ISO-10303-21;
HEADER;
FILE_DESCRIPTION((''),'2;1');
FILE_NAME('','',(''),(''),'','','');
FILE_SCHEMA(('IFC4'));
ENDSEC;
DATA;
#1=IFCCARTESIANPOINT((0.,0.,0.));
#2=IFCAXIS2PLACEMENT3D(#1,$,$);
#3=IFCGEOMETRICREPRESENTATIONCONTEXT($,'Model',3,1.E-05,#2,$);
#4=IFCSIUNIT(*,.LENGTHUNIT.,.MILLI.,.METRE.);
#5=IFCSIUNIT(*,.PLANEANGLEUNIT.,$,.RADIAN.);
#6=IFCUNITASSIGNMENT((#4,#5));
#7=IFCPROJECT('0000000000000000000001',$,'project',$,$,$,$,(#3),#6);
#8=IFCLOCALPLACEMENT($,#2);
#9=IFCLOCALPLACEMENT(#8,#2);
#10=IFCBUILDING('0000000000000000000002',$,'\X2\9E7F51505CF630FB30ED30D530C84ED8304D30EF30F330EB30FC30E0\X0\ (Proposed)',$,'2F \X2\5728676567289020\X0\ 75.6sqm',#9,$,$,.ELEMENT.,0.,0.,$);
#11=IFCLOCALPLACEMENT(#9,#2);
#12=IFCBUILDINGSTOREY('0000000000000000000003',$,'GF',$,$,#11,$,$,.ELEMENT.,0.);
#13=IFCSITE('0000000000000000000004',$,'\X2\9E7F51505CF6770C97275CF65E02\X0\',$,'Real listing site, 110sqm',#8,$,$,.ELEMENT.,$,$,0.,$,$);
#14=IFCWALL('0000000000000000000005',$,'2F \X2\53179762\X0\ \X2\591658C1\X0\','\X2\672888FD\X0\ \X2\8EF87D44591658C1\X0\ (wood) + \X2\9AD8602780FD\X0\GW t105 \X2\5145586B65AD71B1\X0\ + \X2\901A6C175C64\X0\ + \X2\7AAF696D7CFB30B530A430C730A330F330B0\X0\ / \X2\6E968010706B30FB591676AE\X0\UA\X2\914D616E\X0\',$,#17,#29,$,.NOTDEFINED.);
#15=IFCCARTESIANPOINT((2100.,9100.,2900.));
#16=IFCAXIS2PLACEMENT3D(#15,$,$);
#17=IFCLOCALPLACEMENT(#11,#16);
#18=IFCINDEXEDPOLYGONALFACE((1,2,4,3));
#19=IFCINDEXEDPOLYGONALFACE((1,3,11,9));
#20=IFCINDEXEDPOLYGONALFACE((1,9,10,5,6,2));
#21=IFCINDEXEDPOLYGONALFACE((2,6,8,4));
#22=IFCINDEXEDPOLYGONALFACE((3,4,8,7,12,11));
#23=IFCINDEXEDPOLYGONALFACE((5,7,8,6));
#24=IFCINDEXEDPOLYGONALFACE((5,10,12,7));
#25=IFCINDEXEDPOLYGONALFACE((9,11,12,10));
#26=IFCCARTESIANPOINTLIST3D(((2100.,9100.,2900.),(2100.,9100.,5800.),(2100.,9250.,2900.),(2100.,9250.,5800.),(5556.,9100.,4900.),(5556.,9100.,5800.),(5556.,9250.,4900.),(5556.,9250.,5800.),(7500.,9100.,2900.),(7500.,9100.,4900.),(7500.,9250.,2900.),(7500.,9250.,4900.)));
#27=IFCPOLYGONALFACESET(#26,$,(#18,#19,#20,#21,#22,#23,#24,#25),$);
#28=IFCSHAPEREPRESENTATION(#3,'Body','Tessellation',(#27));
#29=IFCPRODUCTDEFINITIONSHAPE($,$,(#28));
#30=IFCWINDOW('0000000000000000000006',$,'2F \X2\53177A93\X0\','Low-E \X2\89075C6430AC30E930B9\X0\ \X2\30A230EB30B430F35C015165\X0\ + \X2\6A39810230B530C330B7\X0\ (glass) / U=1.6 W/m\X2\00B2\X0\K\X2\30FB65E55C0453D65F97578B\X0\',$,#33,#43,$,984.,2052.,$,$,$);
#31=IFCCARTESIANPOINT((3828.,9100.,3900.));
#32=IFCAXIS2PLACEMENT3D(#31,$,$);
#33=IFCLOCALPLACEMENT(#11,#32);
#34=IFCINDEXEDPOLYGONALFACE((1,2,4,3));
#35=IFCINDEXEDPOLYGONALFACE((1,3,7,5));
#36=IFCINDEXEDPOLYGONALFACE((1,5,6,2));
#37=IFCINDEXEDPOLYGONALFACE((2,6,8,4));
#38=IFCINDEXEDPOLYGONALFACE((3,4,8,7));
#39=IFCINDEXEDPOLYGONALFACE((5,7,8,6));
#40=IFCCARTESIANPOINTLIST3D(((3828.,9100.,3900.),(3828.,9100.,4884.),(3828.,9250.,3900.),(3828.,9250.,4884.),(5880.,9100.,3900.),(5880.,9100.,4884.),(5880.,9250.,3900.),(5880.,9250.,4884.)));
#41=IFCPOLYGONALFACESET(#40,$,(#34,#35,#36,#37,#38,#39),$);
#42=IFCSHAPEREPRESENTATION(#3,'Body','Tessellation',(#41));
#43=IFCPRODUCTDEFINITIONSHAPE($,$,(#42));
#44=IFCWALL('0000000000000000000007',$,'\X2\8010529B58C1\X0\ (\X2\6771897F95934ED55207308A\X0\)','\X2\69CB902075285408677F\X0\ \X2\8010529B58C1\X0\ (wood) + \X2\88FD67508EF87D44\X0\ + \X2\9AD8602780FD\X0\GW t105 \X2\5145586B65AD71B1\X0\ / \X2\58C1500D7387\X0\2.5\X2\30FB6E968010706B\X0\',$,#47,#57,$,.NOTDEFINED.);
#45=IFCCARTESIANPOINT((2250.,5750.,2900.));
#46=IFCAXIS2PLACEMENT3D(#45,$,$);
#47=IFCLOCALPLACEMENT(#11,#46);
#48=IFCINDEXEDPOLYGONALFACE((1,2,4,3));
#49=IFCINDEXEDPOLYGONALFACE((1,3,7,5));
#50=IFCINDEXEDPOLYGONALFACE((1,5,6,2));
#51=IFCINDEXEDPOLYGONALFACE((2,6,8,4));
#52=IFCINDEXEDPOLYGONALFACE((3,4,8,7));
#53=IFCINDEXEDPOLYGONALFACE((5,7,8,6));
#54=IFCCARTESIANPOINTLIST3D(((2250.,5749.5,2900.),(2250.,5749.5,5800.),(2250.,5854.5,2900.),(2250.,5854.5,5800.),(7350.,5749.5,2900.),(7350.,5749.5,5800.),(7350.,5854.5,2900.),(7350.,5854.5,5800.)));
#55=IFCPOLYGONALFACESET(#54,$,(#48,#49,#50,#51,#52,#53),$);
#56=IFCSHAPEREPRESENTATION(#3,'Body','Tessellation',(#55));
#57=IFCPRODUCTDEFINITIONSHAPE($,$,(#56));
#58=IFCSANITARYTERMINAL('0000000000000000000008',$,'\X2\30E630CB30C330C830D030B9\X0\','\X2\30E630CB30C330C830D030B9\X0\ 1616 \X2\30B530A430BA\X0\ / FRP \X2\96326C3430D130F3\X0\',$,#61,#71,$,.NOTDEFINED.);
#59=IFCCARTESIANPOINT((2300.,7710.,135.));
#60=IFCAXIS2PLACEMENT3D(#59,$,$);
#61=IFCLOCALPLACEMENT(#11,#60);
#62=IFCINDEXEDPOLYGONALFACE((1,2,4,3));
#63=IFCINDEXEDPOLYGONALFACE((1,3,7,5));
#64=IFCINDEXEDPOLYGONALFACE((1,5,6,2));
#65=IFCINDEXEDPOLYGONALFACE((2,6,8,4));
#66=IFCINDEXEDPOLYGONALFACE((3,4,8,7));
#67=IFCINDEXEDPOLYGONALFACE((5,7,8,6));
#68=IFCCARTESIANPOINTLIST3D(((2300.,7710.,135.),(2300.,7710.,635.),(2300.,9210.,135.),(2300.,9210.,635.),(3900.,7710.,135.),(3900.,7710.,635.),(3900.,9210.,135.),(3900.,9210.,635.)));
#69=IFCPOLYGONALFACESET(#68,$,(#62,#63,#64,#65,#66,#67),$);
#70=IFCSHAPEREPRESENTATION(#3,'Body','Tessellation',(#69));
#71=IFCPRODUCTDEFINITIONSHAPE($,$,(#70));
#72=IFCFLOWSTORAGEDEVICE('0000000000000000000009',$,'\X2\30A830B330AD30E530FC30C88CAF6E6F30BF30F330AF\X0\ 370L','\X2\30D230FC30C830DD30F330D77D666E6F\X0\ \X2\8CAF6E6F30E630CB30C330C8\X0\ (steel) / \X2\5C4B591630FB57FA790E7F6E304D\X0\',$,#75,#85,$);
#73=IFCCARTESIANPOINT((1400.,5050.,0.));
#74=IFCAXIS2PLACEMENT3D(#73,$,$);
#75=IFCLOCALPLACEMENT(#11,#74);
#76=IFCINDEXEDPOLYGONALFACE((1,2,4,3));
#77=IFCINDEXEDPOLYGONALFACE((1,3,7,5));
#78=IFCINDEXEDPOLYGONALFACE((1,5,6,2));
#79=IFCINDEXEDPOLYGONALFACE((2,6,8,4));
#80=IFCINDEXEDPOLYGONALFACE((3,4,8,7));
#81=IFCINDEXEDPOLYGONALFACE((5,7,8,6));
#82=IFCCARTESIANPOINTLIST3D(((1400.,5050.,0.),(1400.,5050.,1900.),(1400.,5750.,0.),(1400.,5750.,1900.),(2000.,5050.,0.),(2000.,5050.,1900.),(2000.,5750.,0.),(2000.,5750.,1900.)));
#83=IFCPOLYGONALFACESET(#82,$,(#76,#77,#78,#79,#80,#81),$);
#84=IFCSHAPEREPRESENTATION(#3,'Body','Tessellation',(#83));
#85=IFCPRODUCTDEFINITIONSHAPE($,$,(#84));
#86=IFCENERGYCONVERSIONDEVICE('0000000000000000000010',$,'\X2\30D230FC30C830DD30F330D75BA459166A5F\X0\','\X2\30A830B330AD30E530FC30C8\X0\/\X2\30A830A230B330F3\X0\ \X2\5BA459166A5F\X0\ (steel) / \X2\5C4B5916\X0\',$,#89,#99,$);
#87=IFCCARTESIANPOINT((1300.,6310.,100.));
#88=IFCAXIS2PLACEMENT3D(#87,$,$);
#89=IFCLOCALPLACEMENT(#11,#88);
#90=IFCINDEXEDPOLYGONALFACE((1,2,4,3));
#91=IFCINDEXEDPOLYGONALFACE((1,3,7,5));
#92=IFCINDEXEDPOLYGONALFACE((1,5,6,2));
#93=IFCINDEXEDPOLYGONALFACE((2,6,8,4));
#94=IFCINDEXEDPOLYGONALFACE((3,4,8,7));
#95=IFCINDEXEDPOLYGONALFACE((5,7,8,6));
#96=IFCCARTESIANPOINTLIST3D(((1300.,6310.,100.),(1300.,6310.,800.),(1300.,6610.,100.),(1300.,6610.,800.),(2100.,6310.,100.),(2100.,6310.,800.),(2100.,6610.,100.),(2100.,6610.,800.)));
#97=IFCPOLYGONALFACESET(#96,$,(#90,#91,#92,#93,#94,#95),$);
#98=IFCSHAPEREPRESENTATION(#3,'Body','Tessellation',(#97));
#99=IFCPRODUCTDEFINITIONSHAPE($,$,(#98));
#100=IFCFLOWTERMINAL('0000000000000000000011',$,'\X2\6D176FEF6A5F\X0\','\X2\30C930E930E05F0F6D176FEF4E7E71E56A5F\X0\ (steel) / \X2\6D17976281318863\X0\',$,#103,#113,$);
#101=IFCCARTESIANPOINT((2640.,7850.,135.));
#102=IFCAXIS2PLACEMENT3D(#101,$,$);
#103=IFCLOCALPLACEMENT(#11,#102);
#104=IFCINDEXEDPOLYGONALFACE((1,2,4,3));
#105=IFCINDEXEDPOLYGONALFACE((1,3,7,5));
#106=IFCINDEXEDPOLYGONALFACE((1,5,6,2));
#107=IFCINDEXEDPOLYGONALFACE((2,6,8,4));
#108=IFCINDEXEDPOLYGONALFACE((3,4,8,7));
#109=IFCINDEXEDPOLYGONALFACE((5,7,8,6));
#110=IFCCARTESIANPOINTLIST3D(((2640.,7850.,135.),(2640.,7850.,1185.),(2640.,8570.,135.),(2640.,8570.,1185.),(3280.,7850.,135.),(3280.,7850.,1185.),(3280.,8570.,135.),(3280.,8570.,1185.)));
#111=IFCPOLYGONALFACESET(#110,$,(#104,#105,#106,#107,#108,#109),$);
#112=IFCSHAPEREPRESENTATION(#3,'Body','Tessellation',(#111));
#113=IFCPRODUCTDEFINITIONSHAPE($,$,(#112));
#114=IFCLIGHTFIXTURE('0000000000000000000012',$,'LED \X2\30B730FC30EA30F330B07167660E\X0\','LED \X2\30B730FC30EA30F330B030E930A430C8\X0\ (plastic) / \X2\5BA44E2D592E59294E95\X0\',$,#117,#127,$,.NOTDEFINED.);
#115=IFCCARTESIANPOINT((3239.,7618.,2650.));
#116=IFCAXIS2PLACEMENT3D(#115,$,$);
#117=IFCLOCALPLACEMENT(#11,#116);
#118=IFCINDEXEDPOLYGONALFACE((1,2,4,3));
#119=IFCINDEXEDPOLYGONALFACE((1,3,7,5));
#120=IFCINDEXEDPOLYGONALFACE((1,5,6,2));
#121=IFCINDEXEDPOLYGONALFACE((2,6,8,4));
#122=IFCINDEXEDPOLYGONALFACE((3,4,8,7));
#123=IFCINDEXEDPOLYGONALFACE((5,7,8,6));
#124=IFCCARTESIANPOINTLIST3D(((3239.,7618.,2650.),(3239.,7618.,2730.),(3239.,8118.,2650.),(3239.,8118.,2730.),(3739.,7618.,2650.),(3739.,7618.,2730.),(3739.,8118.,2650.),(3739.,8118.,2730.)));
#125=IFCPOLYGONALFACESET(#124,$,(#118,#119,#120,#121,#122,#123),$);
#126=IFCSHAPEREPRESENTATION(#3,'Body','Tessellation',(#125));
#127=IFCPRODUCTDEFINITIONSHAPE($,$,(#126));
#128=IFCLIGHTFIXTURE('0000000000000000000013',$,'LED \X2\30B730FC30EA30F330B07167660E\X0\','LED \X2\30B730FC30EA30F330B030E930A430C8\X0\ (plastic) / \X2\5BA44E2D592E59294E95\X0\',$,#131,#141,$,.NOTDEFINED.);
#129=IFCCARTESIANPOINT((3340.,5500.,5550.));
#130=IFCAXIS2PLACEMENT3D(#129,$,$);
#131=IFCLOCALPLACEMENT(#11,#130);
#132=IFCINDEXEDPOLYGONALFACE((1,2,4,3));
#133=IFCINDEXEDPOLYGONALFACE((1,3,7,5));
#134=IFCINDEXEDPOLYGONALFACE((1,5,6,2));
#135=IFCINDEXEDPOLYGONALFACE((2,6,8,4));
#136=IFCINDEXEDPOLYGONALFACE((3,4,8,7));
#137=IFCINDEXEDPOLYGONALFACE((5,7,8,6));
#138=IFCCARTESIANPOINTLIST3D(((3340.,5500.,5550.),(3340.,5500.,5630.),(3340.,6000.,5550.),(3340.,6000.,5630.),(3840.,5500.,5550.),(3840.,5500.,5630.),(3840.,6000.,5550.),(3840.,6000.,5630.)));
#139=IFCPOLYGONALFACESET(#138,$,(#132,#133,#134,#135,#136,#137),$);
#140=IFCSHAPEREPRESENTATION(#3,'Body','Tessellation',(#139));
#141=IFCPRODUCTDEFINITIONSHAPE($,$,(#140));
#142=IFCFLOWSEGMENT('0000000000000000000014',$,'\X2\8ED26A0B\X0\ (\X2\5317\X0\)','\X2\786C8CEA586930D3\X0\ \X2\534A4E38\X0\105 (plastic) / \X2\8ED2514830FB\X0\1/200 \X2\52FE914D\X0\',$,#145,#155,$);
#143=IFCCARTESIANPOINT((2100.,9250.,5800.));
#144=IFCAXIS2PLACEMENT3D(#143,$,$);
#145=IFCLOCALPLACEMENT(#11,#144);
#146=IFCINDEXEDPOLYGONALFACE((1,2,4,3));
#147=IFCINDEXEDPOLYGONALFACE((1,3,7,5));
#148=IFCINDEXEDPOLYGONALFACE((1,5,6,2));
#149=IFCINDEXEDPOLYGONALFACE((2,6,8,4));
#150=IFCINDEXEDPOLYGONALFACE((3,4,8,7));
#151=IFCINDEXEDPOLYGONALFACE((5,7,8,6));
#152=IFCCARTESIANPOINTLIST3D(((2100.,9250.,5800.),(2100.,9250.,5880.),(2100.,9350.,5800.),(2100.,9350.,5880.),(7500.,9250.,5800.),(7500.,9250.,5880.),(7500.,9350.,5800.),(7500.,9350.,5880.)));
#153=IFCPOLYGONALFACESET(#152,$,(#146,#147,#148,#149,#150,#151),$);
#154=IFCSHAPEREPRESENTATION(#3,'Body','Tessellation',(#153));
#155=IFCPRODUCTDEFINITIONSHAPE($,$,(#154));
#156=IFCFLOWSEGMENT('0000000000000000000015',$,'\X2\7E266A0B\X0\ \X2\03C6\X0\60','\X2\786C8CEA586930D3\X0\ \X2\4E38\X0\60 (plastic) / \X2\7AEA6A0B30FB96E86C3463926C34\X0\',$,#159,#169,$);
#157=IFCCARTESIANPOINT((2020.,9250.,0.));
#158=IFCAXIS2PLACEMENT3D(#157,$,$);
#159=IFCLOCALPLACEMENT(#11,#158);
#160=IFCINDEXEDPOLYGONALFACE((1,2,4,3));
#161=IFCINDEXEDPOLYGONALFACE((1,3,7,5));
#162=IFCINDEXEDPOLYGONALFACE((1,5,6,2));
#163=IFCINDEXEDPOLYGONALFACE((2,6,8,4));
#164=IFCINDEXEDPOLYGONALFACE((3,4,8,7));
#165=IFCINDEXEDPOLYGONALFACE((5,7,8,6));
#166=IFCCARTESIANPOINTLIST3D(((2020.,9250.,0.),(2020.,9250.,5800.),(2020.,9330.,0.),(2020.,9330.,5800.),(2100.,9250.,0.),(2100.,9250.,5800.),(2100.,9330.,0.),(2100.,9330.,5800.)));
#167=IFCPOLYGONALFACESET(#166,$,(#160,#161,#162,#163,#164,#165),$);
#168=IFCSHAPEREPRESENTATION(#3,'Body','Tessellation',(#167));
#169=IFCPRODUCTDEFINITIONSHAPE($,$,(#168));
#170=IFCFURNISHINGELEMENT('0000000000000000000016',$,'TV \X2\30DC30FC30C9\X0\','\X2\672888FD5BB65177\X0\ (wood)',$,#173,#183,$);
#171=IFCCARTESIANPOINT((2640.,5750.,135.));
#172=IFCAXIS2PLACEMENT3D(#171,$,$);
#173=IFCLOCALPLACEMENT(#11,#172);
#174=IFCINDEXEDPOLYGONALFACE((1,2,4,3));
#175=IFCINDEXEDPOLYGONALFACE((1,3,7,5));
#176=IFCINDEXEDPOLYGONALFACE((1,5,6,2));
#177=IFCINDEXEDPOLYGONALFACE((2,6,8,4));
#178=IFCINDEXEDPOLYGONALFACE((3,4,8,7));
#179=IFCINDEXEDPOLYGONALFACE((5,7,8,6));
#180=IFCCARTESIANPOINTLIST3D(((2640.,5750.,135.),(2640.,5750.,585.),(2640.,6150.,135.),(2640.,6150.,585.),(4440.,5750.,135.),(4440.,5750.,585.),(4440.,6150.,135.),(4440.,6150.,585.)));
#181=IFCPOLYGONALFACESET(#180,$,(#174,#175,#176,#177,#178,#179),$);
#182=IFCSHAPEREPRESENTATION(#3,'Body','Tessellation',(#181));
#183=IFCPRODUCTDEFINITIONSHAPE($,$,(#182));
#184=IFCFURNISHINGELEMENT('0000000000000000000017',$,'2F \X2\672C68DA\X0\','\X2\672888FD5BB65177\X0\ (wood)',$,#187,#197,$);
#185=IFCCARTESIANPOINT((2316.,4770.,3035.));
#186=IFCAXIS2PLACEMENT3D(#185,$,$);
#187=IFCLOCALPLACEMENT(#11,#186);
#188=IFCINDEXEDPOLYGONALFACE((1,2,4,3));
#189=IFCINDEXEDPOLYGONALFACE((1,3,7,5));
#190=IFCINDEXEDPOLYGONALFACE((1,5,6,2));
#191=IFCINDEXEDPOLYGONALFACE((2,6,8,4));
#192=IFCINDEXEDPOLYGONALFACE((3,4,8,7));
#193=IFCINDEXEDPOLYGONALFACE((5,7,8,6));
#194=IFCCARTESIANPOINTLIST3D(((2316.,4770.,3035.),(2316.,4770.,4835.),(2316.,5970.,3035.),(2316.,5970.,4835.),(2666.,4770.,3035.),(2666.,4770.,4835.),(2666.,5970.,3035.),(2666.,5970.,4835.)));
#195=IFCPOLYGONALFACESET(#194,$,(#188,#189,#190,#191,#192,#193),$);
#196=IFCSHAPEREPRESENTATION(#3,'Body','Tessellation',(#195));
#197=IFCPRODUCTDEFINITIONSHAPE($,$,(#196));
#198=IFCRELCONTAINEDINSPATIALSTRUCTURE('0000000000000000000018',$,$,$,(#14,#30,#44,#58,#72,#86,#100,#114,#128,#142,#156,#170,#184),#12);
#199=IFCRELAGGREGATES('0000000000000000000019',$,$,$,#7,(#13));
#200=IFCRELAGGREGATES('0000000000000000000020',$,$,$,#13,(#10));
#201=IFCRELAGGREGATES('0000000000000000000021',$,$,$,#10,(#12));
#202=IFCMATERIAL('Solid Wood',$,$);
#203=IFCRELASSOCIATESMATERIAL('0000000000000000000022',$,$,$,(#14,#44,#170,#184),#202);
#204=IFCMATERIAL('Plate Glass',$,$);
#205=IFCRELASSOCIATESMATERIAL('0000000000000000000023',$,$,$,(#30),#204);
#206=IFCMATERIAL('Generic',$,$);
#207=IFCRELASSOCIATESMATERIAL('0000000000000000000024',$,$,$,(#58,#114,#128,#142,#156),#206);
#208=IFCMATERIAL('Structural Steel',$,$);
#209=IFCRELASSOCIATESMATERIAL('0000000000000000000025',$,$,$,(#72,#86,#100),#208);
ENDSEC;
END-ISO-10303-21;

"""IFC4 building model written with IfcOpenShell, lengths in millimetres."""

from ifc_helpers import new_model, si_unit, frame, frame_2d, origin, place, context, project, spatial, rectangle, extrude, material, element, fill, save


model = new_model("IFC4")

# Units and contexts
model_context = context("Model", 3, precision=1e-05, world=origin())
ifc_project = project(units=[si_unit("LENGTHUNIT", "METRE", prefix="MILLI"), si_unit("PLANEANGLEUNIT", "RADIAN")], contexts=[model_context])

# Site, building, storey
site_placement = place(None, origin())
site = spatial("IfcSite", under=ifc_project, at=site_placement, Name="鹿児島県霧島市", ObjectType="Real listing site, 110sqm", CompositionType="ELEMENT", RefElevation=0.0)
building_placement = place(site_placement, origin())
building = spatial("IfcBuilding", under=site, at=building_placement, Name="鹿児島・ロフト付きワンルーム (Proposed)", ObjectType="2F 在来木造 75.6sqm", CompositionType="ELEMENT", ElevationOfRefHeight=0.0, ElevationOfTerrain=0.0)
storey_placement = place(building_placement, origin())
storey = spatial("IfcBuildingStorey", under=building, at=storey_placement, Name="GF", CompositionType="ELEMENT", Elevation=0.0)

# Shared definitions
ifc_material_1 = material(Name="Solid Wood")

# Shared definitions
ifc_material_2 = material(Name="Plate Glass")

# Wall, opening, window
wall_1_placement = place(storey_placement, frame((2100.0, 9100.0, 2900.0)))
wall_1 = element("IfcWall", 1, at=wall_1_placement, inside=storey, material=ifc_material_1, Name="2F 北面 外壁", Description="木製 軸組外壁 (wood) + 高性能GW t105 充填断熱 + 通気層 + 窯業系サイディング / 準耐火・外皮UA配慮", PredefinedType="NOTDEFINED", context=model_context, shape_type="SweptSolid", body=[
    extrude(rectangle(XDim=5400.0, YDim=150.0, at=frame_2d((2700.0, 75.0))), frame((2100.0, 9100.0, 2900.0)), (0.0, 0.0, 1.0), 2900.0),
])
opening_1_placement = place(storey_placement, frame((3828.0, 9100.0, 3900.0)))
opening_1 = element("IfcOpeningElement", 2, at=opening_1_placement, cuts=wall_1, PredefinedType="NOTDEFINED", context=model_context, shape_type="SweptSolid", body=[
    extrude(rectangle(XDim=2052.0, YDim=150.0, at=frame_2d((1026.0, 75.0))), frame((3828.0, 9100.0, 3900.0)), (0.0, 0.0, 1.0), 984.0),
])
window_1_placement = place(storey_placement, frame((3828.0, 9100.0, 3900.0)))
window_1 = element("IfcWindow", 3, at=window_1_placement, inside=storey, material=ifc_material_2, Name="2F 北窓", Description="Low-E 複層ガラス アルゴン封入 + 樹脂サッシ (glass) / U=1.6 W/m²K・日射取得型", OverallHeight=984.0, OverallWidth=2052.0, context=model_context, shape_type="SweptSolid", body=[
    extrude(rectangle(XDim=2052.0, YDim=150.0, at=frame_2d((1026.0, 75.0))), frame((3828.0, 9100.0, 3900.0)), (0.0, 0.0, 1.0), 984.0),
])
fill(opening_1, window_1)

# Wall
wall_2_placement = place(storey_placement, frame((2250.0, 5750.0, 2900.0)))
element("IfcWall", 4, at=wall_2_placement, inside=storey, material=ifc_material_1, Name="耐力壁 (東西間仕切り)", Description="構造用合板 耐力壁 (wood) + 製材軸組 + 高性能GW t105 充填断熱 / 壁倍率2.5・準耐火", PredefinedType="NOTDEFINED", context=model_context, shape_type="SweptSolid", body=[
    extrude(rectangle(XDim=5100.0, YDim=105.0, at=frame_2d((2550.0, 52.0))), frame((2250.0, 5750.0, 2900.0)), (0.0, 0.0, 1.0), 2900.0),
])

# Sanitary terminal
ifc_material_3 = material(Name="Generic")
sanitary_terminal_placement = place(storey_placement, frame((2300.0, 7710.0, 135.0)))
element("IfcSanitaryTerminal", 5, at=sanitary_terminal_placement, inside=storey, material=ifc_material_3, Name="ユニットバス", Description="ユニットバス 1616 サイズ / FRP 防水パン", PredefinedType="NOTDEFINED", context=model_context, shape_type="SweptSolid", body=[
    extrude(rectangle(XDim=1600.0, YDim=1500.0, at=frame_2d((800.0, 750.0))), frame((2300.0, 7710.0, 135.0)), (0.0, 0.0, 1.0), 500.0),
])

# Flow storage device
ifc_material_4 = material(Name="Structural Steel")
flow_storage_device_placement = place(storey_placement, frame((1400.0, 5050.0, 0.0)))
element("IfcFlowStorageDevice", 6, at=flow_storage_device_placement, inside=storey, material=ifc_material_4, Name="エコキュート貯湯タンク 370L", Description="ヒートポンプ給湯 貯湯ユニット (steel) / 屋外・基礎置き", context=model_context, shape_type="SweptSolid", body=[
    extrude(rectangle(XDim=600.0, YDim=700.0, at=frame_2d((300.0, 350.0))), frame((1400.0, 5050.0, 0.0)), (0.0, 0.0, 1.0), 1900.0),
])

# Energy conversion device
energy_conversion_device_placement = place(storey_placement, frame((1300.0, 6310.0, 100.0)))
element("IfcEnergyConversionDevice", 7, at=energy_conversion_device_placement, inside=storey, material=ifc_material_4, Name="ヒートポンプ室外機", Description="エコキュート/エアコン 室外機 (steel) / 屋外", context=model_context, shape_type="SweptSolid", body=[
    extrude(rectangle(XDim=800.0, YDim=300.0, at=frame_2d((400.0, 150.0))), frame((1300.0, 6310.0, 100.0)), (0.0, 0.0, 1.0), 700.0),
])

# Flow terminal
flow_terminal_placement = place(storey_placement, frame((2640.0, 7850.0, 135.0)))
element("IfcFlowTerminal", 8, at=flow_terminal_placement, inside=storey, material=ifc_material_4, Name="洗濯機", Description="ドラム式洗濯乾燥機 (steel) / 洗面脱衣", context=model_context, shape_type="SweptSolid", body=[
    extrude(rectangle(XDim=640.0, YDim=720.0, at=frame_2d((320.0, 360.0))), frame((2640.0, 7850.0, 135.0)), (0.0, 0.0, 1.0), 1050.0),
])

# Light fixtures
light_fixture_1_placement = place(storey_placement, frame((3239.0, 7618.0, 2650.0)))
element("IfcLightFixture", 9, at=light_fixture_1_placement, inside=storey, material=ifc_material_3, Name="LED シーリング照明", Description="LED シーリングライト (plastic) / 室中央天井", PredefinedType="NOTDEFINED", context=model_context, shape_type="SweptSolid", body=[
    extrude(rectangle(XDim=500.0, YDim=500.0, at=frame_2d((250.0, 250.0))), frame((3239.0, 7618.0, 2650.0)), (0.0, 0.0, 1.0), 80.0),
])
light_fixture_2_placement = place(storey_placement, frame((3340.0, 5500.0, 5550.0)))
element("IfcLightFixture", 10, at=light_fixture_2_placement, inside=storey, material=ifc_material_3, Name="LED シーリング照明", Description="LED シーリングライト (plastic) / 室中央天井", PredefinedType="NOTDEFINED", context=model_context, shape_type="SweptSolid", body=[
    extrude(rectangle(XDim=500.0, YDim=500.0, at=frame_2d((250.0, 250.0))), frame((3340.0, 5500.0, 5550.0)), (0.0, 0.0, 1.0), 80.0),
])

# Flow segments
flow_segment_1_placement = place(storey_placement, frame((2100.0, 9250.0, 5800.0)))
element("IfcFlowSegment", 11, at=flow_segment_1_placement, inside=storey, material=ifc_material_3, Name="軒樋 (北)", Description="硬質塩ビ 半丸105 (plastic) / 軒先・1/200 勾配", context=model_context, shape_type="SweptSolid", body=[
    extrude(rectangle(XDim=5400.0, YDim=100.0, at=frame_2d((2700.0, 50.0))), frame((2100.0, 9250.0, 5800.0)), (0.0, 0.0, 1.0), 80.0),
])
flow_segment_2_placement = place(storey_placement, frame((2020.0, 9250.0, 0.0)))
element("IfcFlowSegment", 12, at=flow_segment_2_placement, inside=storey, material=ifc_material_3, Name="縦樋 φ60", Description="硬質塩ビ 丸60 (plastic) / 竪樋・雨水排水", context=model_context, shape_type="SweptSolid", body=[
    extrude(rectangle(XDim=80.0, YDim=80.0, at=frame_2d((40.0, 40.0))), frame((2020.0, 9250.0, 0.0)), (0.0, 0.0, 1.0), 5800.0),
])

# Furnishing elements
furnishing_1_placement = place(storey_placement, frame((2640.0, 5750.0, 135.0)))
element("IfcFurnishingElement", 13, at=furnishing_1_placement, inside=storey, material=ifc_material_1, Name="TV ボード", Description="木製家具 (wood)", context=model_context, shape_type="SweptSolid", body=[
    extrude(rectangle(XDim=1800.0, YDim=400.0, at=frame_2d((900.0, 200.0))), frame((2640.0, 5750.0, 135.0)), (0.0, 0.0, 1.0), 450.0),
])
furnishing_2_placement = place(storey_placement, frame((2316.0, 4770.0, 3035.0)))
element("IfcFurnishingElement", 14, at=furnishing_2_placement, inside=storey, material=ifc_material_1, Name="2F 本棚", Description="木製家具 (wood)", context=model_context, shape_type="SweptSolid", body=[
    extrude(rectangle(XDim=350.0, YDim=1200.0, at=frame_2d((175.0, 600.0))), frame((2316.0, 4770.0, 3035.0)), (0.0, 0.0, 1.0), 1800.0),
])

save(model, "model.ifc")
